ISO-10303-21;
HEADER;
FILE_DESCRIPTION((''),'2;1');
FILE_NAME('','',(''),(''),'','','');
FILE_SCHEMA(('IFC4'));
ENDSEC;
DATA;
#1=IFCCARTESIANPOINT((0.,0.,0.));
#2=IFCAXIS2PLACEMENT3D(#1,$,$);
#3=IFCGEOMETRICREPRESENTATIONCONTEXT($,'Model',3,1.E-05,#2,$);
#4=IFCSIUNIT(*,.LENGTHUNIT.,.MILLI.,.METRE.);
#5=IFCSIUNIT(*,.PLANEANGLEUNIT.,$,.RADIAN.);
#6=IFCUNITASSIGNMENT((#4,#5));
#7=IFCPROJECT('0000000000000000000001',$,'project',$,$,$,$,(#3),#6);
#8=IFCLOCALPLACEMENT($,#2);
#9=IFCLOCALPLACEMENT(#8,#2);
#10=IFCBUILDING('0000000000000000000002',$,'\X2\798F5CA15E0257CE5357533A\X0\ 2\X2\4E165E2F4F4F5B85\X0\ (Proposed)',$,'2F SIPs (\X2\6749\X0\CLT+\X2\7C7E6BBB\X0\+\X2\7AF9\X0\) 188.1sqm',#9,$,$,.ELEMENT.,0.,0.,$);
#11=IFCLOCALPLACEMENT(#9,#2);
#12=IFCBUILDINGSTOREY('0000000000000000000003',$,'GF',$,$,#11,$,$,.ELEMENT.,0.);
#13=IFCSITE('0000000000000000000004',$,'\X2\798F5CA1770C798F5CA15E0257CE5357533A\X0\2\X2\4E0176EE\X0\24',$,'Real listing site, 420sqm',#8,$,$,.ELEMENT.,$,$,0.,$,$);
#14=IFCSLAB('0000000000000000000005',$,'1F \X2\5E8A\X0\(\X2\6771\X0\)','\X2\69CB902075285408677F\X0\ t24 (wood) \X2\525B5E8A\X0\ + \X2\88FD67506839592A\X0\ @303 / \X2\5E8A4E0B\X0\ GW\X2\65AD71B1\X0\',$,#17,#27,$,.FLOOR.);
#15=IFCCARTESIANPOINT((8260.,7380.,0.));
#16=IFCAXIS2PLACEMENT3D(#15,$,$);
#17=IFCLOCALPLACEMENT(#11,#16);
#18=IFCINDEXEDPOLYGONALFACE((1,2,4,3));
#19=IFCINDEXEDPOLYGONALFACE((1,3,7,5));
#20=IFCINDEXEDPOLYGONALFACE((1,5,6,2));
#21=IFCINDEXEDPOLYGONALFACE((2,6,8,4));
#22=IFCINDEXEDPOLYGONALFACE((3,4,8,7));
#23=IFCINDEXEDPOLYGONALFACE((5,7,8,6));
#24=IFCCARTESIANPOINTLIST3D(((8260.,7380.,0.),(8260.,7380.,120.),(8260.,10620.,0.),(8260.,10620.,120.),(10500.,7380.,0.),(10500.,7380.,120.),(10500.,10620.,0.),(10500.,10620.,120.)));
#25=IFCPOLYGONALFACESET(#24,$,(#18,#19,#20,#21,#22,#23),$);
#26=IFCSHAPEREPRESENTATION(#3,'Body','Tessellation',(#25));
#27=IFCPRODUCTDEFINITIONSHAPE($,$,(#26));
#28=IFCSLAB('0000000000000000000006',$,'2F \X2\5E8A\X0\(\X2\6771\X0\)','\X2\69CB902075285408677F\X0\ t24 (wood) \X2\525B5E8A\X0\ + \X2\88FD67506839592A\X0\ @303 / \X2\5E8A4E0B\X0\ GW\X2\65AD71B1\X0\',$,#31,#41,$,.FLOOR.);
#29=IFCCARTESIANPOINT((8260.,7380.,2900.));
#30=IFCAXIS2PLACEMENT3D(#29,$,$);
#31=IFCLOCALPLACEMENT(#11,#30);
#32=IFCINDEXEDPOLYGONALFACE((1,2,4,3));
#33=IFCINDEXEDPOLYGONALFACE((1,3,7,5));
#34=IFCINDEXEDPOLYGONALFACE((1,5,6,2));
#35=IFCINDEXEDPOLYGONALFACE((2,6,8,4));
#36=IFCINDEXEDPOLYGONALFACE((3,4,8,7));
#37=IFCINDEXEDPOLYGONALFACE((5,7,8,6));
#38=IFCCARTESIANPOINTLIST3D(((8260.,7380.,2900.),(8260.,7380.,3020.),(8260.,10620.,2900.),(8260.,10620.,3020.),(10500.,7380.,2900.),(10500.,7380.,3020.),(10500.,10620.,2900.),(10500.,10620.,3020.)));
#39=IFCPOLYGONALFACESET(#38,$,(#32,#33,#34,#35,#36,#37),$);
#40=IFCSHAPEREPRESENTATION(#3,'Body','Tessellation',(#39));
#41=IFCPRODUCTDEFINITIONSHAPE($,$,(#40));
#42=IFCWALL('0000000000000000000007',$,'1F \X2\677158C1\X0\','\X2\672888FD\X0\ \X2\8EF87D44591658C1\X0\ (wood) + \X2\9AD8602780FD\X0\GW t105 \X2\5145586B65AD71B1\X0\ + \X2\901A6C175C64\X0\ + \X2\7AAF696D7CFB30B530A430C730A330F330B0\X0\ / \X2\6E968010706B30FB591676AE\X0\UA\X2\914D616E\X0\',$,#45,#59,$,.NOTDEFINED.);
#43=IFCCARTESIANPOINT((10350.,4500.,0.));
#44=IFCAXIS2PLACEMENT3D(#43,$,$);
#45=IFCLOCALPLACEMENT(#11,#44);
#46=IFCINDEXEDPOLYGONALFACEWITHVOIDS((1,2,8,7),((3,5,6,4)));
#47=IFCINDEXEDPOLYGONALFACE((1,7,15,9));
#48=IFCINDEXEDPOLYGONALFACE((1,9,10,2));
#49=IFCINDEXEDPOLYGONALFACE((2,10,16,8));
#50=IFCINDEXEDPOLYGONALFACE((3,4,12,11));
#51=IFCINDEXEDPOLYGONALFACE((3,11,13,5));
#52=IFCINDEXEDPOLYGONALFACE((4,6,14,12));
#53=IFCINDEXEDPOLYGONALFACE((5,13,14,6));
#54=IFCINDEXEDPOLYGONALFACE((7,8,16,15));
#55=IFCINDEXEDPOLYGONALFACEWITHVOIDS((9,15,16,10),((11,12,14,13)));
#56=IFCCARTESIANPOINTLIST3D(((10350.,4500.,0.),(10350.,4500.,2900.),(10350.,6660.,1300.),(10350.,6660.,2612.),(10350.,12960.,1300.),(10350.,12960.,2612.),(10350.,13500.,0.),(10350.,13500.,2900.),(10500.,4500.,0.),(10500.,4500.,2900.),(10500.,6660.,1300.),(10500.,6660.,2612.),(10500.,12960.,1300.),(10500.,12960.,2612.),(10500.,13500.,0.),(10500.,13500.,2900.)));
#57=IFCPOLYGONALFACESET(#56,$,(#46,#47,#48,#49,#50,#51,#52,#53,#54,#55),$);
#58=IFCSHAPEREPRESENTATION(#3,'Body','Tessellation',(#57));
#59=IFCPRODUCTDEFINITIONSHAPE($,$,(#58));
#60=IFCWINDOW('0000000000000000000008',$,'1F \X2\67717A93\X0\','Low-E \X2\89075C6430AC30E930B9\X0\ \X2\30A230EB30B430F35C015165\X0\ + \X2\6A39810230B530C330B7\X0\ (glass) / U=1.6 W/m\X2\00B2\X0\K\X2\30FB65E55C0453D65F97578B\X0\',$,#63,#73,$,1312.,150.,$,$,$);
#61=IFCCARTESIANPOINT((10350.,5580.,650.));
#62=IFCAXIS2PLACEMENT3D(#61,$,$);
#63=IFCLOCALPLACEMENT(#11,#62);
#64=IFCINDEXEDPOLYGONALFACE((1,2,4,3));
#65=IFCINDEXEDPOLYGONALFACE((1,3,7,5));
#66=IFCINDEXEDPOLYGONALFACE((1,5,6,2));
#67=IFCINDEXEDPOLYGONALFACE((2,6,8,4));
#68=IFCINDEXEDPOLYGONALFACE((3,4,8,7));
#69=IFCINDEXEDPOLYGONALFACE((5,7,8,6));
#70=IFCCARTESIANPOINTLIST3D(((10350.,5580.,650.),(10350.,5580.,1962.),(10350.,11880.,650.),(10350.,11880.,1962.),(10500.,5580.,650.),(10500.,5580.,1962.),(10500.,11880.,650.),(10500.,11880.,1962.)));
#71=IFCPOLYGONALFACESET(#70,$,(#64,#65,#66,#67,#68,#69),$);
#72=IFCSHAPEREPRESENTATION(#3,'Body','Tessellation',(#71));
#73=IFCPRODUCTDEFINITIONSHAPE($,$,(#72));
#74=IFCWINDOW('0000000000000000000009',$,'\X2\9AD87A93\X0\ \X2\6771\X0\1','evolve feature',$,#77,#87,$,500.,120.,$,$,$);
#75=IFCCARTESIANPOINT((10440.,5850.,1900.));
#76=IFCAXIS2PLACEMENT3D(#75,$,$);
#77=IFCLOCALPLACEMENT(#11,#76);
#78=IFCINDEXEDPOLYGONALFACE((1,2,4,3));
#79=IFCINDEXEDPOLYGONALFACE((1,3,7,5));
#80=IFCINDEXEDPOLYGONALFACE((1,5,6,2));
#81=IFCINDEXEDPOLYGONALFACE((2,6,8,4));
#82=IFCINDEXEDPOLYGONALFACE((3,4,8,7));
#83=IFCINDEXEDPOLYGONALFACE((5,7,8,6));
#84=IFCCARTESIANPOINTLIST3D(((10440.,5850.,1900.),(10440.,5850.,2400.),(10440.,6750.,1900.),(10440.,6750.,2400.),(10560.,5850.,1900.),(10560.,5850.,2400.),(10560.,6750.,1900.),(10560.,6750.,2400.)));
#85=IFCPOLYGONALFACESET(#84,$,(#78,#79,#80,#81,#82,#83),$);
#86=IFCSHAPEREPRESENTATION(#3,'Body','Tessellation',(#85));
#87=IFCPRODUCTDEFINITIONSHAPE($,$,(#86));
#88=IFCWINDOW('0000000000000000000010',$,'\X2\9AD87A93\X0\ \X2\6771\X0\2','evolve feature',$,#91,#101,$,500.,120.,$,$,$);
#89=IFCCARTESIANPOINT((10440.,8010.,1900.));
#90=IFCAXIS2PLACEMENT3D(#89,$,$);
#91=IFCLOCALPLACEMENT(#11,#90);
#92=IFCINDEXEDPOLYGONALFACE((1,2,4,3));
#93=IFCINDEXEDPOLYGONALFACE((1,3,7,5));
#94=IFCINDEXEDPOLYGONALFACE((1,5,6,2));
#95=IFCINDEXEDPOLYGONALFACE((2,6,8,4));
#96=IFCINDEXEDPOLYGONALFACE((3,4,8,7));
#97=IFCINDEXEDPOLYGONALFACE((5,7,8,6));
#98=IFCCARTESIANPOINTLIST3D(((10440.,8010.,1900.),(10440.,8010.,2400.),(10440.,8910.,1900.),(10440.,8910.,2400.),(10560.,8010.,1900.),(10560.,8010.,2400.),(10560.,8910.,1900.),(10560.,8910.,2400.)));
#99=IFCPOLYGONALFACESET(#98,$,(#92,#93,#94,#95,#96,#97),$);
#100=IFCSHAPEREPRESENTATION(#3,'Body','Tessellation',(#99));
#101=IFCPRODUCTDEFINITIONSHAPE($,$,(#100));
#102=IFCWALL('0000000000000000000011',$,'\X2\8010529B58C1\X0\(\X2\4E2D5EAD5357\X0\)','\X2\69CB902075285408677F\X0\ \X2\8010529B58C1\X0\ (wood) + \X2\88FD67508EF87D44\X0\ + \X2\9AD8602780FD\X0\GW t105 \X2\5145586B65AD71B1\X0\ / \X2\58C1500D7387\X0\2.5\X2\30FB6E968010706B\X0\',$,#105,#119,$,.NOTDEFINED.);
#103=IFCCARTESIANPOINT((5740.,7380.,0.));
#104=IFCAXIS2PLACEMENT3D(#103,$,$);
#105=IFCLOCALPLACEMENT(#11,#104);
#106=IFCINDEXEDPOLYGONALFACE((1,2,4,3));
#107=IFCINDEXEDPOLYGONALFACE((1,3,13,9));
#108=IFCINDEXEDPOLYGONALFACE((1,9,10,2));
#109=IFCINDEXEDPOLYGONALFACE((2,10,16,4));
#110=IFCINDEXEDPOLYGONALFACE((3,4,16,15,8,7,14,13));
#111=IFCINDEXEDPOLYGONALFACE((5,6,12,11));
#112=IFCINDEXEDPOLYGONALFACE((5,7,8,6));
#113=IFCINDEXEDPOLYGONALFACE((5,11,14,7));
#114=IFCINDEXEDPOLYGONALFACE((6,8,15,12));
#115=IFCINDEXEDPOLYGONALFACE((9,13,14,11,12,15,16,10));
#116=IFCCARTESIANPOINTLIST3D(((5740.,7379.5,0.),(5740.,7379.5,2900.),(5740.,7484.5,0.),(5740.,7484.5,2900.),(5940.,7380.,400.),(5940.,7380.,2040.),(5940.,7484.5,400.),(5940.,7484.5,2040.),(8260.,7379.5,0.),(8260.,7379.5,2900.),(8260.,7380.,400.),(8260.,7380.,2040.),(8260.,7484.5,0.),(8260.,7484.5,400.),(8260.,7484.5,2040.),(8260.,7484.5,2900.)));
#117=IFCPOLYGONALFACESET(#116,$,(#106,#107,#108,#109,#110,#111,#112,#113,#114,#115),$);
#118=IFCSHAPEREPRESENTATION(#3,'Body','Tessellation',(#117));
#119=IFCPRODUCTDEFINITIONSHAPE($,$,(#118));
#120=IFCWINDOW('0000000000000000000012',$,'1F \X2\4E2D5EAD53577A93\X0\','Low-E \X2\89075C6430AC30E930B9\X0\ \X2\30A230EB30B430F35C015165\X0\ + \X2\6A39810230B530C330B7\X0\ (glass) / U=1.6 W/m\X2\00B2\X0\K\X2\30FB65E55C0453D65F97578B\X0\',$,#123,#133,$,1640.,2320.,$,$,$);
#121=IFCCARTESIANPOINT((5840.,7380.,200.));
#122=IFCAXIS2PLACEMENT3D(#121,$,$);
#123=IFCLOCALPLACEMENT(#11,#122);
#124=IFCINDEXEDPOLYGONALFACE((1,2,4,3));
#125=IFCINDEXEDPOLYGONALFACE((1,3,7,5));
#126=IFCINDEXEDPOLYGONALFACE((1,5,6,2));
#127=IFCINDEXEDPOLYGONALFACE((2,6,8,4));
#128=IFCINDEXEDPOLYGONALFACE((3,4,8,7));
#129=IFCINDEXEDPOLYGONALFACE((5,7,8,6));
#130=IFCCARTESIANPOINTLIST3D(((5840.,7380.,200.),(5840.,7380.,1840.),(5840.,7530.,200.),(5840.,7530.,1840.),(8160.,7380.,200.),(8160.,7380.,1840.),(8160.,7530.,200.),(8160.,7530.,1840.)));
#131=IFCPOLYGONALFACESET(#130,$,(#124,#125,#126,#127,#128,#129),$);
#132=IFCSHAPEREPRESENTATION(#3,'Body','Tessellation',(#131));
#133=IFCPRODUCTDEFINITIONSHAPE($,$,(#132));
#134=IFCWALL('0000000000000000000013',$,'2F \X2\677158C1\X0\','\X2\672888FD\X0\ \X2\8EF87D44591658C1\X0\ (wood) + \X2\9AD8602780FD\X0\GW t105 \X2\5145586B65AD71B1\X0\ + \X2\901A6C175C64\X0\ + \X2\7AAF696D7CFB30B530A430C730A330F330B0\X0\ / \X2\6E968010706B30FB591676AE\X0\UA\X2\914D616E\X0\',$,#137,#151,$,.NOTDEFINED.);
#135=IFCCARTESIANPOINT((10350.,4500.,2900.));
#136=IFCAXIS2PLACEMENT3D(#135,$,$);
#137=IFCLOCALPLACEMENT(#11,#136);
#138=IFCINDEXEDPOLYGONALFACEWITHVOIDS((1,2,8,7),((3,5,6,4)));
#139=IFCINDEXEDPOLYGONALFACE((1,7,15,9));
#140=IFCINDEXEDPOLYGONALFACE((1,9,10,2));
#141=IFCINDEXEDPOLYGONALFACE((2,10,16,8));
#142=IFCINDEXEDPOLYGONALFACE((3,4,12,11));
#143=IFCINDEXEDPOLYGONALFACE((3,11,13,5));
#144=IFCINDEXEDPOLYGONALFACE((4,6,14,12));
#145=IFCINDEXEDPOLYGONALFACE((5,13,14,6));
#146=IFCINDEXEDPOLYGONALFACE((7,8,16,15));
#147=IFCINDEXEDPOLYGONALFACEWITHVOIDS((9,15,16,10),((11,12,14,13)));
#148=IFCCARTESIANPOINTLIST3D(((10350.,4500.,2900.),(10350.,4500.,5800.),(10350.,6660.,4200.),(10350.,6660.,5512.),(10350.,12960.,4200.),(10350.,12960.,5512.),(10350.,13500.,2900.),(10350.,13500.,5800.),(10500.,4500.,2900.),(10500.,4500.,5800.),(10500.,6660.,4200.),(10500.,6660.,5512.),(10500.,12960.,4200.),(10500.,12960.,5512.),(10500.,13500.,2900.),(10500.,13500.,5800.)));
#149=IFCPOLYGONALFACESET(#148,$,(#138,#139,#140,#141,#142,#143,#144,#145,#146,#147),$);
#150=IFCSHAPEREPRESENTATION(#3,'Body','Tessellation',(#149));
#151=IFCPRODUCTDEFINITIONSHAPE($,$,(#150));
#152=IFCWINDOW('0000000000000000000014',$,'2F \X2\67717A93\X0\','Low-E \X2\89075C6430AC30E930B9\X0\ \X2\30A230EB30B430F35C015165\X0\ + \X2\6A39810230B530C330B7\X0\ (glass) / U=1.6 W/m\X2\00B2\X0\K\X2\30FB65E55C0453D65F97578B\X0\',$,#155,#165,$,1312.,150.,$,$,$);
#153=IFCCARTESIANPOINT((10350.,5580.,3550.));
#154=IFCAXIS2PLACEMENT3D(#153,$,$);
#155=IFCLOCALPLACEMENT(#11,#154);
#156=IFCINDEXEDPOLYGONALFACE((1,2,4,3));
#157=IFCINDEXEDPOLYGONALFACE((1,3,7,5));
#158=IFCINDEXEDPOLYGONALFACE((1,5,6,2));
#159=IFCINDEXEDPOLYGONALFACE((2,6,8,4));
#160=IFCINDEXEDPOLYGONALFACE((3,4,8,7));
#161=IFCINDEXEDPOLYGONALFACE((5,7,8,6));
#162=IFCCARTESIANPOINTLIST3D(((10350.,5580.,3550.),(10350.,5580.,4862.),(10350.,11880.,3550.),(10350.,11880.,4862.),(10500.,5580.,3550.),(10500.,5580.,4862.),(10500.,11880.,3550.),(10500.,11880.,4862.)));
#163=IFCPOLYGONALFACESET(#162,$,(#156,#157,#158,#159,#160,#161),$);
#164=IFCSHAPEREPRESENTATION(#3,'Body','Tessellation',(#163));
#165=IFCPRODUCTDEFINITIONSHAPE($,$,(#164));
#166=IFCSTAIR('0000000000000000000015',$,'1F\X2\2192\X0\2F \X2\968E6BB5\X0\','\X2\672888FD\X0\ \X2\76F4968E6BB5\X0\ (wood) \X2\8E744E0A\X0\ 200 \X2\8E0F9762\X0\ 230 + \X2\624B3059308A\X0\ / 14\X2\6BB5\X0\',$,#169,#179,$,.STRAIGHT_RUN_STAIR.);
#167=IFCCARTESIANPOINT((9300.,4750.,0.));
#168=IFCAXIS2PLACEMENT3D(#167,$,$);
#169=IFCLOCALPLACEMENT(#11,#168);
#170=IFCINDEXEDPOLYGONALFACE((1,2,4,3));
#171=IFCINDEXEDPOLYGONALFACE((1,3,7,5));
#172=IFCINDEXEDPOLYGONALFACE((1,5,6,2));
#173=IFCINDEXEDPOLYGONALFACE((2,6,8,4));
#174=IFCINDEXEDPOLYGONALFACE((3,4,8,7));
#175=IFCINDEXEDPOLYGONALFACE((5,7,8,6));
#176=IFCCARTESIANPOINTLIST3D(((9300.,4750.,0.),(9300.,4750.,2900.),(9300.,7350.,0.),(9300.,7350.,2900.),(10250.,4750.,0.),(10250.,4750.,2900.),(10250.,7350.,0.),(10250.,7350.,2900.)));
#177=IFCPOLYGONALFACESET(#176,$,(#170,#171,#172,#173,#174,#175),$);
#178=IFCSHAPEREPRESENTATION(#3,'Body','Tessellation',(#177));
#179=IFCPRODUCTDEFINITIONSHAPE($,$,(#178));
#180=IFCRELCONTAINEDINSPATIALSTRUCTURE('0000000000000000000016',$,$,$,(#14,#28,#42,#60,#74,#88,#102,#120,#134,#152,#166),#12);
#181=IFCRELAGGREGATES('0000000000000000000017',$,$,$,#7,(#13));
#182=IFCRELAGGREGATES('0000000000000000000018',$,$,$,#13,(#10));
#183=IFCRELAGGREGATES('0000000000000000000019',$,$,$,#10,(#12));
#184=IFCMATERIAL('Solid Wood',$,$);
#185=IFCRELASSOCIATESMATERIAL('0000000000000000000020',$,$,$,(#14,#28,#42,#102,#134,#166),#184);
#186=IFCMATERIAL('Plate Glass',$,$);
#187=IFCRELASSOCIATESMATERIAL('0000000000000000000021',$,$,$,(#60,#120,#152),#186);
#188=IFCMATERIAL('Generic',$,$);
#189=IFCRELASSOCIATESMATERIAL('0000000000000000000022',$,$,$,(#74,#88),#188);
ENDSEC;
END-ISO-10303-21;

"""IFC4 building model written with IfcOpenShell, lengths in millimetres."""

from ifc_helpers import new_model, si_unit, frame, frame_2d, origin, place, context, project, spatial, rectangle, extrude, material, element, fill, save


model = new_model("IFC4")

# Units and contexts
model_context = context("Model", 3, precision=1e-05, world=origin())
ifc_project = project(units=[si_unit("LENGTHUNIT", "METRE", prefix="MILLI"), si_unit("PLANEANGLEUNIT", "RADIAN")], contexts=[model_context])

# Site, building, storey
site_placement = place(None, origin())
site = spatial("IfcSite", under=ifc_project, at=site_placement, Name="福岡県福岡市城南区2丁目24", ObjectType="Real listing site, 420sqm", CompositionType="ELEMENT", RefElevation=0.0)
building_placement = place(site_placement, origin())
building = spatial("IfcBuilding", under=site, at=building_placement, Name="福岡市城南区 2世帯住宅 (Proposed)", ObjectType="2F SIPs (杉CLT+籾殻+竹) 188.1sqm", CompositionType="ELEMENT", ElevationOfRefHeight=0.0, ElevationOfTerrain=0.0)
storey_placement = place(building_placement, origin())
storey = spatial("IfcBuildingStorey", under=building, at=storey_placement, Name="GF", CompositionType="ELEMENT", Elevation=0.0)

# Slabs
ifc_material_1 = material(Name="Solid Wood")
slab_1_placement = place(storey_placement, frame((8260.0, 7380.0, 0.0)))
element("IfcSlab", 1, at=slab_1_placement, inside=storey, material=ifc_material_1, Name="1F 床(東)", Description="構造用合板 t24 (wood) 剛床 + 製材根太 @303 / 床下 GW断熱", PredefinedType="FLOOR", context=model_context, shape_type="SweptSolid", body=[
    extrude(rectangle(XDim=2240.0, YDim=3240.0, at=frame_2d((1120.0, 1620.0))), frame((8260.0, 7380.0, 0.0)), (0.0, 0.0, 1.0), 120.0),
])
slab_2_placement = place(storey_placement, frame((8260.0, 7380.0, 2900.0)))
element("IfcSlab", 2, at=slab_2_placement, inside=storey, material=ifc_material_1, Name="2F 床(東)", Description="構造用合板 t24 (wood) 剛床 + 製材根太 @303 / 床下 GW断熱", PredefinedType="FLOOR", context=model_context, shape_type="SweptSolid", body=[
    extrude(rectangle(XDim=2240.0, YDim=3240.0, at=frame_2d((1120.0, 1620.0))), frame((8260.0, 7380.0, 2900.0)), (0.0, 0.0, 1.0), 120.0),
])

# Wall, openings, windows
wall_1_placement = place(storey_placement, frame((10350.0, 4500.0, 0.0)))
wall_1 = element("IfcWall", 3, at=wall_1_placement, inside=storey, material=ifc_material_1, Name="1F 東壁", Description="木製 軸組外壁 (wood) + 高性能GW t105 充填断熱 + 通気層 + 窯業系サイディング / 準耐火・外皮UA配慮", PredefinedType="NOTDEFINED", context=model_context, shape_type="SweptSolid", body=[
    extrude(rectangle(XDim=150.0, YDim=9000.0, at=frame_2d((75.0, 4500.0))), frame((10350.0, 4500.0, 0.0)), (0.0, 0.0, 1.0), 2900.0),
])
opening_1_placement = place(storey_placement, frame((10350.0, 5580.0, 650.0)))
opening_1 = element("IfcOpeningElement", 4, at=opening_1_placement, cuts=wall_1, PredefinedType="NOTDEFINED", context=model_context, shape_type="SweptSolid", body=[
    extrude(rectangle(XDim=150.0, YDim=6300.0, at=frame_2d((75.0, 3150.0))), frame((10350.0, 5580.0, 650.0)), (0.0, 0.0, 1.0), 1312.0),
])
opening_2_placement = place(storey_placement, frame((10440.0, 5850.0, 1900.0)))
opening_2 = element("IfcOpeningElement", 5, at=opening_2_placement, cuts=wall_1, PredefinedType="NOTDEFINED", context=model_context, shape_type="SweptSolid", body=[
    extrude(rectangle(XDim=120.0, YDim=900.0, at=frame_2d((60.0, 450.0))), frame((10440.0, 5850.0, 1900.0)), (0.0, 0.0, 1.0), 500.0),
])
opening_3_placement = place(storey_placement, frame((10440.0, 8010.0, 1900.0)))
opening_3 = element("IfcOpeningElement", 6, at=opening_3_placement, cuts=wall_1, PredefinedType="NOTDEFINED", context=model_context, shape_type="SweptSolid", body=[
    extrude(rectangle(XDim=120.0, YDim=900.0, at=frame_2d((60.0, 450.0))), frame((10440.0, 8010.0, 1900.0)), (0.0, 0.0, 1.0), 500.0),
])
ifc_material_2 = material(Name="Plate Glass")
window_1_placement = place(storey_placement, frame((10350.0, 5580.0, 650.0)))
window_1 = element("IfcWindow", 7, at=window_1_placement, inside=storey, material=ifc_material_2, Name="1F 東窓", Description="Low-E 複層ガラス アルゴン封入 + 樹脂サッシ (glass) / U=1.6 W/m²K・日射取得型", OverallHeight=1312.0, OverallWidth=150.0, context=model_context, shape_type="SweptSolid", body=[
    extrude(rectangle(XDim=150.0, YDim=6300.0, at=frame_2d((75.0, 3150.0))), frame((10350.0, 5580.0, 650.0)), (0.0, 0.0, 1.0), 1312.0),
])
fill(opening_1, window_1)
ifc_material_3 = material(Name="Generic")
window_2_placement = place(storey_placement, frame((10440.0, 5850.0, 1900.0)))
window_2 = element("IfcWindow", 8, at=window_2_placement, inside=storey, material=ifc_material_3, Name="高窓 東1", Description="evolve feature", OverallHeight=500.0, OverallWidth=120.0, context=model_context, shape_type="SweptSolid", body=[
    extrude(rectangle(XDim=120.0, YDim=900.0, at=frame_2d((60.0, 450.0))), frame((10440.0, 5850.0, 1900.0)), (0.0, 0.0, 1.0), 500.0),
])
fill(opening_2, window_2)
window_3_placement = place(storey_placement, frame((10440.0, 8010.0, 1900.0)))
window_3 = element("IfcWindow", 9, at=window_3_placement, inside=storey, material=ifc_material_3, Name="高窓 東2", Description="evolve feature", OverallHeight=500.0, OverallWidth=120.0, context=model_context, shape_type="SweptSolid", body=[
    extrude(rectangle(XDim=120.0, YDim=900.0, at=frame_2d((60.0, 450.0))), frame((10440.0, 8010.0, 1900.0)), (0.0, 0.0, 1.0), 500.0),
])
fill(opening_3, window_3)

# Wall, opening, window
wall_2_placement = place(storey_placement, frame((5740.0, 7380.0, 0.0)))
wall_2 = element("IfcWall", 10, at=wall_2_placement, inside=storey, material=ifc_material_1, Name="耐力壁(中庭南)", Description="構造用合板 耐力壁 (wood) + 製材軸組 + 高性能GW t105 充填断熱 / 壁倍率2.5・準耐火", PredefinedType="NOTDEFINED", context=model_context, shape_type="SweptSolid", body=[
    extrude(rectangle(XDim=2520.0, YDim=105.0, at=frame_2d((1260.0, 52.0))), frame((5740.0, 7380.0, 0.0)), (0.0, 0.0, 1.0), 2900.0),
])
opening_4_placement = place(storey_placement, frame((5840.0, 7380.0, 200.0)))
opening_4 = element("IfcOpeningElement", 11, at=opening_4_placement, cuts=wall_2, PredefinedType="NOTDEFINED", context=model_context, shape_type="SweptSolid", body=[
    extrude(rectangle(XDim=2320.0, YDim=150.0, at=frame_2d((1160.0, 75.0))), frame((5840.0, 7380.0, 200.0)), (0.0, 0.0, 1.0), 1640.0),
])
window_4_placement = place(storey_placement, frame((5840.0, 7380.0, 200.0)))
window_4 = element("IfcWindow", 12, at=window_4_placement, inside=storey, material=ifc_material_2, Name="1F 中庭南窓", Description="Low-E 複層ガラス アルゴン封入 + 樹脂サッシ (glass) / U=1.6 W/m²K・日射取得型", OverallHeight=1640.0, OverallWidth=2320.0, context=model_context, shape_type="SweptSolid", body=[
    extrude(rectangle(XDim=2320.0, YDim=150.0, at=frame_2d((1160.0, 75.0))), frame((5840.0, 7380.0, 200.0)), (0.0, 0.0, 1.0), 1640.0),
])
fill(opening_4, window_4)

# Wall, opening, window
wall_3_placement = place(storey_placement, frame((10350.0, 4500.0, 2900.0)))
wall_3 = element("IfcWall", 13, at=wall_3_placement, inside=storey, material=ifc_material_1, Name="2F 東壁", Description="木製 軸組外壁 (wood) + 高性能GW t105 充填断熱 + 通気層 + 窯業系サイディング / 準耐火・外皮UA配慮", PredefinedType="NOTDEFINED", context=model_context, shape_type="SweptSolid", body=[
    extrude(rectangle(XDim=150.0, YDim=9000.0, at=frame_2d((75.0, 4500.0))), frame((10350.0, 4500.0, 2900.0)), (0.0, 0.0, 1.0), 2900.0),
])
opening_5_placement = place(storey_placement, frame((10350.0, 5580.0, 3550.0)))
opening_5 = element("IfcOpeningElement", 14, at=opening_5_placement, cuts=wall_3, PredefinedType="NOTDEFINED", context=model_context, shape_type="SweptSolid", body=[
    extrude(rectangle(XDim=150.0, YDim=6300.0, at=frame_2d((75.0, 3150.0))), frame((10350.0, 5580.0, 3550.0)), (0.0, 0.0, 1.0), 1312.0),
])
window_5_placement = place(storey_placement, frame((10350.0, 5580.0, 3550.0)))
window_5 = element("IfcWindow", 15, at=window_5_placement, inside=storey, material=ifc_material_2, Name="2F 東窓", Description="Low-E 複層ガラス アルゴン封入 + 樹脂サッシ (glass) / U=1.6 W/m²K・日射取得型", OverallHeight=1312.0, OverallWidth=150.0, context=model_context, shape_type="SweptSolid", body=[
    extrude(rectangle(XDim=150.0, YDim=6300.0, at=frame_2d((75.0, 3150.0))), frame((10350.0, 5580.0, 3550.0)), (0.0, 0.0, 1.0), 1312.0),
])
fill(opening_5, window_5)

# Stair
stair_placement = place(storey_placement, frame((9300.0, 4750.0, 0.0)))
element("IfcStair", 16, at=stair_placement, inside=storey, material=ifc_material_1, Name="1F→2F 階段", Description="木製 直階段 (wood) 蹴上 200 踏面 230 + 手すり / 14段", PredefinedType="STRAIGHT_RUN_STAIR", context=model_context, shape_type="SweptSolid", body=[
    extrude(rectangle(XDim=950.0, YDim=2600.0, at=frame_2d((475.0, 1300.0))), frame((9300.0, 4750.0, 0.0)), (0.0, 0.0, 1.0), 2900.0),
])

save(model, "model.ifc")
